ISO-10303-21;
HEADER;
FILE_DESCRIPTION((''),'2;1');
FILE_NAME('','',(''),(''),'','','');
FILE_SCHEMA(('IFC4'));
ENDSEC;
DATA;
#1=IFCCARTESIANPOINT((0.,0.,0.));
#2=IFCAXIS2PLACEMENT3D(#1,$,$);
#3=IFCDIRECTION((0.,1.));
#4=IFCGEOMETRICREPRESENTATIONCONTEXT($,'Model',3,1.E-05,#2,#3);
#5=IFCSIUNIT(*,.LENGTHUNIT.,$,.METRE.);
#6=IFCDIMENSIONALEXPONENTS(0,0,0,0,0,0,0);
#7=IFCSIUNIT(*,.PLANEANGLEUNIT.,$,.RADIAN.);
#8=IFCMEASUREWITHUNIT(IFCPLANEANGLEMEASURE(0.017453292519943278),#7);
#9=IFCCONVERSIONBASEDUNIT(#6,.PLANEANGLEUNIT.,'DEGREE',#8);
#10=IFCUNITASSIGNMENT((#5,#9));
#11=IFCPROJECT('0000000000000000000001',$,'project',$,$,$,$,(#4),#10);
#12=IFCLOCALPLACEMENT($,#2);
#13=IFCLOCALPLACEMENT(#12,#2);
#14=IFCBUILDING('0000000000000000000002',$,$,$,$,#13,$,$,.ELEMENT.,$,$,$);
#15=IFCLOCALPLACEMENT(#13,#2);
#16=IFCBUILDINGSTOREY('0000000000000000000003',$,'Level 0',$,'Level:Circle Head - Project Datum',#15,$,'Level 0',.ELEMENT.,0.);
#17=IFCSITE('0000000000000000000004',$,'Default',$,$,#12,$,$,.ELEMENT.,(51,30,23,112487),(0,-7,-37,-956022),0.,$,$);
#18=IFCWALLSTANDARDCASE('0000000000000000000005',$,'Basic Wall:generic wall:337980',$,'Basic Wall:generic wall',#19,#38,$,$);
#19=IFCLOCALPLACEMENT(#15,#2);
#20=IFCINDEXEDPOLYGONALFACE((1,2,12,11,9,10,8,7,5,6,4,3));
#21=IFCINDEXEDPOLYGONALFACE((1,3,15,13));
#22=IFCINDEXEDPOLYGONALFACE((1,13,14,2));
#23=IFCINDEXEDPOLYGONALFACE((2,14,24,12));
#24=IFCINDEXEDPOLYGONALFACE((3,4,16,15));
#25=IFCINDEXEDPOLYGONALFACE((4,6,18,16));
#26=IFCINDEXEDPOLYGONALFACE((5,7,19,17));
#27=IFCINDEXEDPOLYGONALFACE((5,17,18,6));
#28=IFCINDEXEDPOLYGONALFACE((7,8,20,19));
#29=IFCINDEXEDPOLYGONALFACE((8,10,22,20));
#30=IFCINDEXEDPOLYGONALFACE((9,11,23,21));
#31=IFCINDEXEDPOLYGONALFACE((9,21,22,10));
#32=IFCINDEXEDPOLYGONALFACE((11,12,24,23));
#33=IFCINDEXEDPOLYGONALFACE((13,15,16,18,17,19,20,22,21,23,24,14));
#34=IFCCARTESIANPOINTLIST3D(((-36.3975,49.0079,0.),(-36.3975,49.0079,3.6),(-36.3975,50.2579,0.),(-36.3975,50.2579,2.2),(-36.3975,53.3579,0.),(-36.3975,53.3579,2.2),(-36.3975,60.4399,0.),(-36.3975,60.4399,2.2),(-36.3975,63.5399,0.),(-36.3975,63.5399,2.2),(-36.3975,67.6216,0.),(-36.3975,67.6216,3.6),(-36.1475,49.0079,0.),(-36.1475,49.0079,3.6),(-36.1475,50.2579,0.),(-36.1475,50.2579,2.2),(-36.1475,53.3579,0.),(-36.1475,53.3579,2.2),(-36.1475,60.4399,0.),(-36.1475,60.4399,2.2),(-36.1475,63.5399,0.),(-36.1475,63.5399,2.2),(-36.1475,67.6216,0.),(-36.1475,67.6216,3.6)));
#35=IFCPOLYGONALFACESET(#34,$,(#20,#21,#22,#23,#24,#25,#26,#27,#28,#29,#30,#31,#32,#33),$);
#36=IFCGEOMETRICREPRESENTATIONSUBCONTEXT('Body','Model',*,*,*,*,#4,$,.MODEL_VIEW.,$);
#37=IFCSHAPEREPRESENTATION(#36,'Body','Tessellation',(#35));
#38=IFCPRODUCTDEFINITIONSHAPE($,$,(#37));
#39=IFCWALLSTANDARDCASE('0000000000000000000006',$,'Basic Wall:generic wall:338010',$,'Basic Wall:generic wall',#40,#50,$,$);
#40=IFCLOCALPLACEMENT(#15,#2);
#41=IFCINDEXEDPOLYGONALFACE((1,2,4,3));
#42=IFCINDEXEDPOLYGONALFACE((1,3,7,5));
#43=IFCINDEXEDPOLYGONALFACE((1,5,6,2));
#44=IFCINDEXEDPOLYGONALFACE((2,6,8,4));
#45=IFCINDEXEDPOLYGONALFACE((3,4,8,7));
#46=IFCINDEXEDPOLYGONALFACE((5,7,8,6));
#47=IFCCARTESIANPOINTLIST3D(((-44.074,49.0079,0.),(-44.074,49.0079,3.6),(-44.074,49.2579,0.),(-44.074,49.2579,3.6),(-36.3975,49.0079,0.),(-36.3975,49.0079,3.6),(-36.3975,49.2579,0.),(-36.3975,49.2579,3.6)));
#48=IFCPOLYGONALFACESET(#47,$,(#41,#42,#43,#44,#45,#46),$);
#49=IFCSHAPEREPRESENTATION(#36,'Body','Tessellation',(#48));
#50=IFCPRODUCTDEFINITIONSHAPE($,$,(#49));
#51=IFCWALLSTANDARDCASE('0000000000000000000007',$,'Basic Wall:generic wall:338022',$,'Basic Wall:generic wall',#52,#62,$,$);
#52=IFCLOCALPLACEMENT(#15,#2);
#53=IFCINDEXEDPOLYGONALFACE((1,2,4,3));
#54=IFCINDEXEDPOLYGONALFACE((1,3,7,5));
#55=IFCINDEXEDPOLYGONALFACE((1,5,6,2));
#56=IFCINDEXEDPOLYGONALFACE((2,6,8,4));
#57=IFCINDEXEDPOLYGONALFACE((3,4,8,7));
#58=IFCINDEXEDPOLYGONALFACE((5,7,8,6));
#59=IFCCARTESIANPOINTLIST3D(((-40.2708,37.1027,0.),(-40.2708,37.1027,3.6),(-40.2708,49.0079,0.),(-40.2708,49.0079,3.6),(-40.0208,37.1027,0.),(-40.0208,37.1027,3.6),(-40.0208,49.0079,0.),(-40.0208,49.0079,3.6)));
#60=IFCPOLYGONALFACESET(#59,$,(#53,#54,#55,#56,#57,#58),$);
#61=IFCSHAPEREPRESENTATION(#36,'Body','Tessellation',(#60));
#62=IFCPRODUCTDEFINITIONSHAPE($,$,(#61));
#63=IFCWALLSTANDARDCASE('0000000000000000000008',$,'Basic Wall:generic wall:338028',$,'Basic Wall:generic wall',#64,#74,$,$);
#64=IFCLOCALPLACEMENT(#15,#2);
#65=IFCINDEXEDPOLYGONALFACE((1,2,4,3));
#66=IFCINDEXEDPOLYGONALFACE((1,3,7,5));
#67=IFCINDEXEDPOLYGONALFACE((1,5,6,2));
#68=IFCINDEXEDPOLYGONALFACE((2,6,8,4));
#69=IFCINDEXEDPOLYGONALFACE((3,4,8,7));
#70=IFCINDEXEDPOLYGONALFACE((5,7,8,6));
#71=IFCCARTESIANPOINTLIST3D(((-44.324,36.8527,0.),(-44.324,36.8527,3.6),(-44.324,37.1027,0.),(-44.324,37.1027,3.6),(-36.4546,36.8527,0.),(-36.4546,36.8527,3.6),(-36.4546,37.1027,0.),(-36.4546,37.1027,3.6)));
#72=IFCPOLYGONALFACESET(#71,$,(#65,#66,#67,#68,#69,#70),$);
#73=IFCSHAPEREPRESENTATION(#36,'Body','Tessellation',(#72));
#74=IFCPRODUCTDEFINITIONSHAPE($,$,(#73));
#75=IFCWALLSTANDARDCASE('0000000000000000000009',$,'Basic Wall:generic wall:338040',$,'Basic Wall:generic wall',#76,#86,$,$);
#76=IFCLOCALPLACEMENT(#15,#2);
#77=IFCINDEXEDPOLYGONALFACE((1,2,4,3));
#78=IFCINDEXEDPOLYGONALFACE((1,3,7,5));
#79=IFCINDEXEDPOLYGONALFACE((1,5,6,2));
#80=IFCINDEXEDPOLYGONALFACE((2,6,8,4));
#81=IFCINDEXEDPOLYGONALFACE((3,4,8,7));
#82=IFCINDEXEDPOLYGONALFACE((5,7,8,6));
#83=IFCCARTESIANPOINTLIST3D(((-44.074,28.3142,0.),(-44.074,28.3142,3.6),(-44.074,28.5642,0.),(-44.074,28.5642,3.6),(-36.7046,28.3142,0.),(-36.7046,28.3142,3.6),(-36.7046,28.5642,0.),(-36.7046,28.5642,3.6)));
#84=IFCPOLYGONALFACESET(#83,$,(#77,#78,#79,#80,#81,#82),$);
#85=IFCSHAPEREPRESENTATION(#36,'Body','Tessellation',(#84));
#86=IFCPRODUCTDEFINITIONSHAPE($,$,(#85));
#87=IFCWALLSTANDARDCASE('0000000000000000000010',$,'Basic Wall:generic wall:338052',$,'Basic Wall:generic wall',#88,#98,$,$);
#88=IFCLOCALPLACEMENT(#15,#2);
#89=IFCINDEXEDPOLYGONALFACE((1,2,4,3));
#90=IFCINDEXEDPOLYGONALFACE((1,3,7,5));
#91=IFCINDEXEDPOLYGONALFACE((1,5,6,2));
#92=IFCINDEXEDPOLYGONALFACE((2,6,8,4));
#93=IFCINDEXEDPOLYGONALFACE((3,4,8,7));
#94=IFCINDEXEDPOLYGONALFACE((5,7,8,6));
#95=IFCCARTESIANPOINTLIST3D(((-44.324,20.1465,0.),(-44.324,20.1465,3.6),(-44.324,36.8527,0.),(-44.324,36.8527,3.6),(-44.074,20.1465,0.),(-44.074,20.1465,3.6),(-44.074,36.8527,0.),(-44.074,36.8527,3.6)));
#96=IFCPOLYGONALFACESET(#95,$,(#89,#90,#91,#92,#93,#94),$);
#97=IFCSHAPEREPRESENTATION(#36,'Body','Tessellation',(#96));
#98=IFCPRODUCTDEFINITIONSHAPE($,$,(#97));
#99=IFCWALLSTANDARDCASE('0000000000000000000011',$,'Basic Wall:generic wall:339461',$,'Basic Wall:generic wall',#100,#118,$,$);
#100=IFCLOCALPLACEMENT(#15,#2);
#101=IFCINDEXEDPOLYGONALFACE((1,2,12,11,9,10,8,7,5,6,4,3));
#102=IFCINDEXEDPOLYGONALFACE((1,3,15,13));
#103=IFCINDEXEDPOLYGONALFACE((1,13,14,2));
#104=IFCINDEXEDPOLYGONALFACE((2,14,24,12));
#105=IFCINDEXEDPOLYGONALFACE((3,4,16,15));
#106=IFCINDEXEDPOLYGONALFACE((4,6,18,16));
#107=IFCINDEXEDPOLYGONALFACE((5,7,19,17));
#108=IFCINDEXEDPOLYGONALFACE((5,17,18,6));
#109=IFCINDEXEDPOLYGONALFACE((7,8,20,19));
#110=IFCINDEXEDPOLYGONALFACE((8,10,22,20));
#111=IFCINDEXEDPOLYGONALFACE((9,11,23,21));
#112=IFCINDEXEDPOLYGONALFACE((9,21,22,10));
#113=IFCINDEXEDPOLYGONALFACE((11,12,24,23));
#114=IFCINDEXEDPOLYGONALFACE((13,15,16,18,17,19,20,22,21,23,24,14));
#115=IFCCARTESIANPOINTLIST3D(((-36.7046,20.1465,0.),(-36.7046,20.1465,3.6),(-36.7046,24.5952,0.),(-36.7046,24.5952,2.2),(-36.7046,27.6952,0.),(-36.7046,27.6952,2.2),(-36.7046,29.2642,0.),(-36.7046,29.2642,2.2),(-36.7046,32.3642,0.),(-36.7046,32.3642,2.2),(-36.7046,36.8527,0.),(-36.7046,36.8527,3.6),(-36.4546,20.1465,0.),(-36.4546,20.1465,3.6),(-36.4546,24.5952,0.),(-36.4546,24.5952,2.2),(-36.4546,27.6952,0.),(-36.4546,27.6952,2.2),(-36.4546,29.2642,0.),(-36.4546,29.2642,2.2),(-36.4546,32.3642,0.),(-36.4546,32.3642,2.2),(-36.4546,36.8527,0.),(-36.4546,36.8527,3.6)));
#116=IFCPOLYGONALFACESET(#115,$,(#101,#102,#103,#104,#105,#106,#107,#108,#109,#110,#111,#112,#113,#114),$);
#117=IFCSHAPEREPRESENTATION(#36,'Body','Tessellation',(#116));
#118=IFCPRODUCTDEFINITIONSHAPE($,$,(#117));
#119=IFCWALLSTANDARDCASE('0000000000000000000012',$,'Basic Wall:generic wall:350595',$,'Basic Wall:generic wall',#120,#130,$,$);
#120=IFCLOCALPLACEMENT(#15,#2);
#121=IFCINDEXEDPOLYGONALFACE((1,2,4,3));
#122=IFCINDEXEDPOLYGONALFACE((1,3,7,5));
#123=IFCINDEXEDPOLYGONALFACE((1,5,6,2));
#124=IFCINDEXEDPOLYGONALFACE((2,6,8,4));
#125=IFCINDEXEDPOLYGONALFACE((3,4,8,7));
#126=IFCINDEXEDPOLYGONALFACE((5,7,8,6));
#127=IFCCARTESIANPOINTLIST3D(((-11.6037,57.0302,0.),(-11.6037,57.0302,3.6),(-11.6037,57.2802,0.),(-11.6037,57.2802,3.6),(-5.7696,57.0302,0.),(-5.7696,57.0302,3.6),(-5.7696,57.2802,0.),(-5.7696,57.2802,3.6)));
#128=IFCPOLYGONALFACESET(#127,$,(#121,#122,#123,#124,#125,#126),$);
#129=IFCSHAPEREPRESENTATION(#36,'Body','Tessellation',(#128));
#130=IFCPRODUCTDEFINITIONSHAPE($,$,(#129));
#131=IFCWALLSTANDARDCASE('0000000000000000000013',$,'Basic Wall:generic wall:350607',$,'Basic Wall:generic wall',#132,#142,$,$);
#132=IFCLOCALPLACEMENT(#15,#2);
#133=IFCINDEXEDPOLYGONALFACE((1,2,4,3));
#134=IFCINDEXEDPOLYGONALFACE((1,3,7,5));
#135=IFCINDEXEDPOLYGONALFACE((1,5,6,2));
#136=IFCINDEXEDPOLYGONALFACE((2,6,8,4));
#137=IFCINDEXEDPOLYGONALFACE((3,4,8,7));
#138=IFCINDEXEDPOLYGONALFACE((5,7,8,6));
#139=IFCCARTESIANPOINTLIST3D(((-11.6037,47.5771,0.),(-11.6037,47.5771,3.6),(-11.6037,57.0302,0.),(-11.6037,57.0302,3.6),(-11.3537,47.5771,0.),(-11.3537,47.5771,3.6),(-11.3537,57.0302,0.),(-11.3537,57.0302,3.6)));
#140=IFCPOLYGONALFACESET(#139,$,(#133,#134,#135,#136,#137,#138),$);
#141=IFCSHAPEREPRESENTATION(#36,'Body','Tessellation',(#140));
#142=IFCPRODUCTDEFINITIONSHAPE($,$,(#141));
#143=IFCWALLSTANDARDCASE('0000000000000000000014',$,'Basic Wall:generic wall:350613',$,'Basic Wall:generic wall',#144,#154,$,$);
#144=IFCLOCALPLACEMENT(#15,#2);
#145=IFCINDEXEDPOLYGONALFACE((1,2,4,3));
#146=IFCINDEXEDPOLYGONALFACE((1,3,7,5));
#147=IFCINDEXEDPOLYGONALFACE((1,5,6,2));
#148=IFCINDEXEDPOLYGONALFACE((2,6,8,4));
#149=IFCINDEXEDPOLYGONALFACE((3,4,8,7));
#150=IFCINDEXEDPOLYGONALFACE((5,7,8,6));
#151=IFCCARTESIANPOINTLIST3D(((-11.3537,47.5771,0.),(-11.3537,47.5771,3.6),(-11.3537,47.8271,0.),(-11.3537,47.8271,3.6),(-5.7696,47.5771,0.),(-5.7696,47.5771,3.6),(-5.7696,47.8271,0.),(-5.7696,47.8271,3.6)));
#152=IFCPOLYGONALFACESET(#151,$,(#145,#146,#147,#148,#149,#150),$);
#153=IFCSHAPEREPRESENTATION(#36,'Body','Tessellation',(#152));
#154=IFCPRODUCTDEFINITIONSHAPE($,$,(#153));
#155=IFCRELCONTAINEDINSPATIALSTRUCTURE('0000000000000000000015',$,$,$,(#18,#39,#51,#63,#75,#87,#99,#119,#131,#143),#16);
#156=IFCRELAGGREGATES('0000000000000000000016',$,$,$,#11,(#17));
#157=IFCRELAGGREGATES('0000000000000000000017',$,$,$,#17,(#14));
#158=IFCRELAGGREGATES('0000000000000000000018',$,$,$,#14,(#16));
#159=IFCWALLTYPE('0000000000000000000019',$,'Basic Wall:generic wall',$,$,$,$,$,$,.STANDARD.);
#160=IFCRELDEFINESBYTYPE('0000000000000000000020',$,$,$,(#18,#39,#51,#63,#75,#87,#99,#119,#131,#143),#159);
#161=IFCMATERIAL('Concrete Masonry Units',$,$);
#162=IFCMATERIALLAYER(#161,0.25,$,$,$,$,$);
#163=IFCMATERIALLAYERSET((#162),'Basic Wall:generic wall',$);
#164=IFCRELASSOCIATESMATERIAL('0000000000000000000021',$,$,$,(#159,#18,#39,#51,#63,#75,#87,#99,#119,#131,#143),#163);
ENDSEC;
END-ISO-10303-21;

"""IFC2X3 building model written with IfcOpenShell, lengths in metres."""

from ifc_helpers import new_model, entity, si_unit, converted_unit, direction, frame, frame_2d, origin, place, context, subcontext, project, spatial, rectangle, extrude, material, layer, layer_set, layer_usage, type_object, element, save


model = new_model("IFC2X3")

# Units and contexts
model_context = context("Model", 3, precision=1e-05, world=origin(), true_north=direction((0.0, 1.0)))
body_context = subcontext(model_context, "Body", "Model", "MODEL_VIEW")
ifc_project = project(units=[si_unit("LENGTHUNIT", "METRE"), converted_unit("PLANEANGLEUNIT", "DEGREE", entity("IfcPlaneAngleMeasure", 0.017453292519943278), si_unit("PLANEANGLEUNIT", "RADIAN"), dimensions=[0, 0, 0, 0, 0, 0, 0])], contexts=[model_context])

# Site, building, storey
site_placement = place(None, origin())
site = spatial("IfcSite", under=ifc_project, at=site_placement, Name="Default", CompositionType="ELEMENT", RefLatitude=(51, 30, 23, 112487), RefLongitude=(0, -7, -37, -956022), RefElevation=0.0)
building_placement = place(site_placement, origin())
building = spatial("IfcBuilding", under=site, at=building_placement, CompositionType="ELEMENT")
storey_placement = place(building_placement, origin())
storey = spatial("IfcBuildingStorey", under=building, at=storey_placement, Name="Level 0", ObjectType="Level:Circle Head - Project Datum", LongName="Level 0", CompositionType="ELEMENT", Elevation=0.0)

# Wall, openings
ifc_material = material(Name="Concrete Masonry Units")
ifc_layer = layer(ifc_material, 0.25)
ifc_layer_set = layer_set([ifc_layer], Name="Basic Wall:generic wall")
ifc_layer_usage_1 = layer_usage(ifc_layer_set, "AXIS2", "NEGATIVE", 0.125)
wall_type = type_object("IfcWallType", Name="Basic Wall:generic wall", PredefinedType="STANDARD", material=ifc_layer_set)
wall_1_placement = place(storey_placement, frame((-36.2725, 49.0079, 0.0), z_axis=(0.0, 0.0, 1.0), x_axis=(0.0, 1.0, 0.0)))
wall_1 = element("IfcWallStandardCase", 1, at=wall_1_placement, inside=storey, type_object=wall_type, material=ifc_layer_usage_1, Name="Basic Wall:generic wall:337980", ObjectType="Basic Wall:generic wall", context=body_context, shape_type="SweptSolid", body=[
    extrude(rectangle(XDim=18.6137, YDim=0.25, at=frame_2d((9.3069, 0.0), x_axis=(-1.0, 0.0))), origin(), (0.0, 0.0, 1.0), 3.6),
])
opening_1_placement = place(wall_1_placement, frame((11.432, -0.125, 0.0)))
element("IfcOpeningElement", 2, at=opening_1_placement, cuts=wall_1, ObjectType="Opening", context=body_context, shape_type="SweptSolid", body=[
    extrude(rectangle(XDim=2.2, YDim=3.1, at=frame_2d((1.1, 1.55), x_axis=(1.0, 0.0))), frame((0.0, 0.0, 0.0), z_axis=(0.0, 1.0, 0.0), x_axis=(0.0, 0.0, 1.0)), (0.0, 0.0, 1.0), 0.25),
])
opening_2_placement = place(wall_1_placement, frame((1.25, -0.125, 0.0)))
element("IfcOpeningElement", 3, at=opening_2_placement, cuts=wall_1, ObjectType="Opening", context=body_context, shape_type="SweptSolid", body=[
    extrude(rectangle(XDim=2.2, YDim=3.1, at=frame_2d((1.1, 1.55), x_axis=(1.0, 0.0))), frame((0.0, 0.0, 0.0), z_axis=(0.0, 1.0, 0.0), x_axis=(0.0, 0.0, 1.0)), (0.0, 0.0, 1.0), 0.25),
])

# Walls
ifc_layer_usage_2 = layer_usage(ifc_layer_set, "AXIS2", "NEGATIVE", 0.125)
wall_2_placement = place(storey_placement, frame((-44.074, 49.1329, 0.0)))
element("IfcWallStandardCase", 4, at=wall_2_placement, inside=storey, type_object=wall_type, material=ifc_layer_usage_2, Name="Basic Wall:generic wall:338010", ObjectType="Basic Wall:generic wall", context=body_context, shape_type="SweptSolid", body=[
    extrude(rectangle(XDim=7.6765, YDim=0.25, at=frame_2d((3.8382, 0.0), x_axis=(-1.0, 0.0))), origin(), (0.0, 0.0, 1.0), 3.6),
])
ifc_layer_usage_3 = layer_usage(ifc_layer_set, "AXIS2", "NEGATIVE", 0.125)
wall_3_placement = place(storey_placement, frame((-40.1458, 49.0079, 0.0), z_axis=(0.0, 0.0, 1.0), x_axis=(0.0, -1.0, 0.0)))
element("IfcWallStandardCase", 5, at=wall_3_placement, inside=storey, type_object=wall_type, material=ifc_layer_usage_3, Name="Basic Wall:generic wall:338022", ObjectType="Basic Wall:generic wall", context=body_context, shape_type="SweptSolid", body=[
    extrude(rectangle(XDim=11.9052, YDim=0.25, at=frame_2d((5.9526, 0.0), x_axis=(-1.0, 0.0))), origin(), (0.0, 0.0, 1.0), 3.6),
])
ifc_layer_usage_4 = layer_usage(ifc_layer_set, "AXIS2", "NEGATIVE", 0.125)
wall_4_placement = place(storey_placement, frame((-36.4546, 36.9777, 0.0), z_axis=(0.0, 0.0, 1.0), x_axis=(-1.0, 0.0, 0.0)))
element("IfcWallStandardCase", 6, at=wall_4_placement, inside=storey, type_object=wall_type, material=ifc_layer_usage_4, Name="Basic Wall:generic wall:338028", ObjectType="Basic Wall:generic wall", context=body_context, shape_type="SweptSolid", body=[
    extrude(rectangle(XDim=7.8694, YDim=0.25, at=frame_2d((3.9347, 0.0), x_axis=(-1.0, 0.0))), origin(), (0.0, 0.0, 1.0), 3.6),
])
ifc_layer_usage_5 = layer_usage(ifc_layer_set, "AXIS2", "NEGATIVE", 0.125)
wall_5_placement = place(storey_placement, frame((-36.7046, 28.4392, 0.0), z_axis=(0.0, 0.0, 1.0), x_axis=(-1.0, 0.0, 0.0)))
element("IfcWallStandardCase", 7, at=wall_5_placement, inside=storey, type_object=wall_type, material=ifc_layer_usage_5, Name="Basic Wall:generic wall:338040", ObjectType="Basic Wall:generic wall", context=body_context, shape_type="SweptSolid", body=[
    extrude(rectangle(XDim=7.3694, YDim=0.25, at=frame_2d((3.6847, 0.0), x_axis=(-1.0, 0.0))), origin(), (0.0, 0.0, 1.0), 3.6),
])
ifc_layer_usage_6 = layer_usage(ifc_layer_set, "AXIS2", "NEGATIVE", 0.125)
wall_6_placement = place(storey_placement, frame((-44.199, 36.8527, 0.0), z_axis=(0.0, 0.0, 1.0), x_axis=(0.0, -1.0, 0.0)))
element("IfcWallStandardCase", 8, at=wall_6_placement, inside=storey, type_object=wall_type, material=ifc_layer_usage_6, Name="Basic Wall:generic wall:338052", ObjectType="Basic Wall:generic wall", context=body_context, shape_type="SweptSolid", body=[
    extrude(rectangle(XDim=16.7062, YDim=0.25, at=frame_2d((8.3531, 0.0), x_axis=(-1.0, 0.0))), origin(), (0.0, 0.0, 1.0), 3.6),
])

# Wall, openings
ifc_layer_usage_7 = layer_usage(ifc_layer_set, "AXIS2", "NEGATIVE", 0.125)
wall_7_placement = place(storey_placement, frame((-36.5796, 36.8527, 0.0), z_axis=(0.0, 0.0, 1.0), x_axis=(0.0, -1.0, 0.0)))
wall_7 = element("IfcWallStandardCase", 9, at=wall_7_placement, inside=storey, type_object=wall_type, material=ifc_layer_usage_7, Name="Basic Wall:generic wall:339461", ObjectType="Basic Wall:generic wall", context=body_context, shape_type="SweptSolid", body=[
    extrude(rectangle(XDim=16.7062, YDim=0.25, at=frame_2d((8.3531, 0.0), x_axis=(-1.0, 0.0))), origin(), (0.0, 0.0, 1.0), 3.6),
])
opening_3_placement = place(wall_7_placement, frame((7.5885, 0.125, 0.0)))
element("IfcOpeningElement", 10, at=opening_3_placement, cuts=wall_7, ObjectType="Opening", context=body_context, shape_type="SweptSolid", body=[
    extrude(rectangle(XDim=2.2, YDim=3.1, at=frame_2d((1.1, 1.55), x_axis=(1.0, 0.0))), frame((0.0, 0.0, 0.0), z_axis=(0.0, -1.0, 0.0), x_axis=(0.0, 0.0, 1.0)), (0.0, 0.0, 1.0), 0.25),
])
opening_4_placement = place(wall_7_placement, frame((12.2575, 0.125, 0.0)))
element("IfcOpeningElement", 11, at=opening_4_placement, cuts=wall_7, ObjectType="Opening", context=body_context, shape_type="SweptSolid", body=[
    extrude(rectangle(XDim=2.2, YDim=3.1, at=frame_2d((1.1, 1.55), x_axis=(1.0, 0.0))), frame((0.0, 0.0, 0.0), z_axis=(0.0, -1.0, 0.0), x_axis=(0.0, 0.0, 1.0)), (0.0, 0.0, 1.0), 0.25),
])

# Walls
ifc_layer_usage_8 = layer_usage(ifc_layer_set, "AXIS2", "NEGATIVE", 0.125)
wall_8_placement = place(storey_placement, frame((-11.6037, 57.1552, 0.0)))
element("IfcWallStandardCase", 12, at=wall_8_placement, inside=storey, type_object=wall_type, material=ifc_layer_usage_8, Name="Basic Wall:generic wall:350595", ObjectType="Basic Wall:generic wall", context=body_context, shape_type="SweptSolid", body=[
    extrude(rectangle(XDim=5.8341, YDim=0.25, at=frame_2d((2.9171, 0.0), x_axis=(-1.0, 0.0))), origin(), (0.0, 0.0, 1.0), 3.6),
])
ifc_layer_usage_9 = layer_usage(ifc_layer_set, "AXIS2", "NEGATIVE", 0.125)
wall_9_placement = place(storey_placement, frame((-11.4787, 47.5771, 0.0), z_axis=(0.0, 0.0, 1.0), x_axis=(0.0, 1.0, 0.0)))
element("IfcWallStandardCase", 13, at=wall_9_placement, inside=storey, type_object=wall_type, material=ifc_layer_usage_9, Name="Basic Wall:generic wall:350607", ObjectType="Basic Wall:generic wall", context=body_context, shape_type="SweptSolid", body=[
    extrude(rectangle(XDim=9.4531, YDim=0.25, at=frame_2d((4.7265, 0.0), x_axis=(-1.0, 0.0))), origin(), (0.0, 0.0, 1.0), 3.6),
])
ifc_layer_usage_10 = layer_usage(ifc_layer_set, "AXIS2", "NEGATIVE", 0.125)
wall_10_placement = place(storey_placement, frame((-5.7696, 47.7021, 0.0), z_axis=(0.0, 0.0, 1.0), x_axis=(-1.0, 0.0, 0.0)))
element("IfcWallStandardCase", 14, at=wall_10_placement, inside=storey, type_object=wall_type, material=ifc_layer_usage_10, Name="Basic Wall:generic wall:350613", ObjectType="Basic Wall:generic wall", context=body_context, shape_type="SweptSolid", body=[
    extrude(rectangle(XDim=5.5841, YDim=0.25, at=frame_2d((2.7921, 0.0), x_axis=(-1.0, 0.0))), origin(), (0.0, 0.0, 1.0), 3.6),
])

save(model, "model.ifc")
